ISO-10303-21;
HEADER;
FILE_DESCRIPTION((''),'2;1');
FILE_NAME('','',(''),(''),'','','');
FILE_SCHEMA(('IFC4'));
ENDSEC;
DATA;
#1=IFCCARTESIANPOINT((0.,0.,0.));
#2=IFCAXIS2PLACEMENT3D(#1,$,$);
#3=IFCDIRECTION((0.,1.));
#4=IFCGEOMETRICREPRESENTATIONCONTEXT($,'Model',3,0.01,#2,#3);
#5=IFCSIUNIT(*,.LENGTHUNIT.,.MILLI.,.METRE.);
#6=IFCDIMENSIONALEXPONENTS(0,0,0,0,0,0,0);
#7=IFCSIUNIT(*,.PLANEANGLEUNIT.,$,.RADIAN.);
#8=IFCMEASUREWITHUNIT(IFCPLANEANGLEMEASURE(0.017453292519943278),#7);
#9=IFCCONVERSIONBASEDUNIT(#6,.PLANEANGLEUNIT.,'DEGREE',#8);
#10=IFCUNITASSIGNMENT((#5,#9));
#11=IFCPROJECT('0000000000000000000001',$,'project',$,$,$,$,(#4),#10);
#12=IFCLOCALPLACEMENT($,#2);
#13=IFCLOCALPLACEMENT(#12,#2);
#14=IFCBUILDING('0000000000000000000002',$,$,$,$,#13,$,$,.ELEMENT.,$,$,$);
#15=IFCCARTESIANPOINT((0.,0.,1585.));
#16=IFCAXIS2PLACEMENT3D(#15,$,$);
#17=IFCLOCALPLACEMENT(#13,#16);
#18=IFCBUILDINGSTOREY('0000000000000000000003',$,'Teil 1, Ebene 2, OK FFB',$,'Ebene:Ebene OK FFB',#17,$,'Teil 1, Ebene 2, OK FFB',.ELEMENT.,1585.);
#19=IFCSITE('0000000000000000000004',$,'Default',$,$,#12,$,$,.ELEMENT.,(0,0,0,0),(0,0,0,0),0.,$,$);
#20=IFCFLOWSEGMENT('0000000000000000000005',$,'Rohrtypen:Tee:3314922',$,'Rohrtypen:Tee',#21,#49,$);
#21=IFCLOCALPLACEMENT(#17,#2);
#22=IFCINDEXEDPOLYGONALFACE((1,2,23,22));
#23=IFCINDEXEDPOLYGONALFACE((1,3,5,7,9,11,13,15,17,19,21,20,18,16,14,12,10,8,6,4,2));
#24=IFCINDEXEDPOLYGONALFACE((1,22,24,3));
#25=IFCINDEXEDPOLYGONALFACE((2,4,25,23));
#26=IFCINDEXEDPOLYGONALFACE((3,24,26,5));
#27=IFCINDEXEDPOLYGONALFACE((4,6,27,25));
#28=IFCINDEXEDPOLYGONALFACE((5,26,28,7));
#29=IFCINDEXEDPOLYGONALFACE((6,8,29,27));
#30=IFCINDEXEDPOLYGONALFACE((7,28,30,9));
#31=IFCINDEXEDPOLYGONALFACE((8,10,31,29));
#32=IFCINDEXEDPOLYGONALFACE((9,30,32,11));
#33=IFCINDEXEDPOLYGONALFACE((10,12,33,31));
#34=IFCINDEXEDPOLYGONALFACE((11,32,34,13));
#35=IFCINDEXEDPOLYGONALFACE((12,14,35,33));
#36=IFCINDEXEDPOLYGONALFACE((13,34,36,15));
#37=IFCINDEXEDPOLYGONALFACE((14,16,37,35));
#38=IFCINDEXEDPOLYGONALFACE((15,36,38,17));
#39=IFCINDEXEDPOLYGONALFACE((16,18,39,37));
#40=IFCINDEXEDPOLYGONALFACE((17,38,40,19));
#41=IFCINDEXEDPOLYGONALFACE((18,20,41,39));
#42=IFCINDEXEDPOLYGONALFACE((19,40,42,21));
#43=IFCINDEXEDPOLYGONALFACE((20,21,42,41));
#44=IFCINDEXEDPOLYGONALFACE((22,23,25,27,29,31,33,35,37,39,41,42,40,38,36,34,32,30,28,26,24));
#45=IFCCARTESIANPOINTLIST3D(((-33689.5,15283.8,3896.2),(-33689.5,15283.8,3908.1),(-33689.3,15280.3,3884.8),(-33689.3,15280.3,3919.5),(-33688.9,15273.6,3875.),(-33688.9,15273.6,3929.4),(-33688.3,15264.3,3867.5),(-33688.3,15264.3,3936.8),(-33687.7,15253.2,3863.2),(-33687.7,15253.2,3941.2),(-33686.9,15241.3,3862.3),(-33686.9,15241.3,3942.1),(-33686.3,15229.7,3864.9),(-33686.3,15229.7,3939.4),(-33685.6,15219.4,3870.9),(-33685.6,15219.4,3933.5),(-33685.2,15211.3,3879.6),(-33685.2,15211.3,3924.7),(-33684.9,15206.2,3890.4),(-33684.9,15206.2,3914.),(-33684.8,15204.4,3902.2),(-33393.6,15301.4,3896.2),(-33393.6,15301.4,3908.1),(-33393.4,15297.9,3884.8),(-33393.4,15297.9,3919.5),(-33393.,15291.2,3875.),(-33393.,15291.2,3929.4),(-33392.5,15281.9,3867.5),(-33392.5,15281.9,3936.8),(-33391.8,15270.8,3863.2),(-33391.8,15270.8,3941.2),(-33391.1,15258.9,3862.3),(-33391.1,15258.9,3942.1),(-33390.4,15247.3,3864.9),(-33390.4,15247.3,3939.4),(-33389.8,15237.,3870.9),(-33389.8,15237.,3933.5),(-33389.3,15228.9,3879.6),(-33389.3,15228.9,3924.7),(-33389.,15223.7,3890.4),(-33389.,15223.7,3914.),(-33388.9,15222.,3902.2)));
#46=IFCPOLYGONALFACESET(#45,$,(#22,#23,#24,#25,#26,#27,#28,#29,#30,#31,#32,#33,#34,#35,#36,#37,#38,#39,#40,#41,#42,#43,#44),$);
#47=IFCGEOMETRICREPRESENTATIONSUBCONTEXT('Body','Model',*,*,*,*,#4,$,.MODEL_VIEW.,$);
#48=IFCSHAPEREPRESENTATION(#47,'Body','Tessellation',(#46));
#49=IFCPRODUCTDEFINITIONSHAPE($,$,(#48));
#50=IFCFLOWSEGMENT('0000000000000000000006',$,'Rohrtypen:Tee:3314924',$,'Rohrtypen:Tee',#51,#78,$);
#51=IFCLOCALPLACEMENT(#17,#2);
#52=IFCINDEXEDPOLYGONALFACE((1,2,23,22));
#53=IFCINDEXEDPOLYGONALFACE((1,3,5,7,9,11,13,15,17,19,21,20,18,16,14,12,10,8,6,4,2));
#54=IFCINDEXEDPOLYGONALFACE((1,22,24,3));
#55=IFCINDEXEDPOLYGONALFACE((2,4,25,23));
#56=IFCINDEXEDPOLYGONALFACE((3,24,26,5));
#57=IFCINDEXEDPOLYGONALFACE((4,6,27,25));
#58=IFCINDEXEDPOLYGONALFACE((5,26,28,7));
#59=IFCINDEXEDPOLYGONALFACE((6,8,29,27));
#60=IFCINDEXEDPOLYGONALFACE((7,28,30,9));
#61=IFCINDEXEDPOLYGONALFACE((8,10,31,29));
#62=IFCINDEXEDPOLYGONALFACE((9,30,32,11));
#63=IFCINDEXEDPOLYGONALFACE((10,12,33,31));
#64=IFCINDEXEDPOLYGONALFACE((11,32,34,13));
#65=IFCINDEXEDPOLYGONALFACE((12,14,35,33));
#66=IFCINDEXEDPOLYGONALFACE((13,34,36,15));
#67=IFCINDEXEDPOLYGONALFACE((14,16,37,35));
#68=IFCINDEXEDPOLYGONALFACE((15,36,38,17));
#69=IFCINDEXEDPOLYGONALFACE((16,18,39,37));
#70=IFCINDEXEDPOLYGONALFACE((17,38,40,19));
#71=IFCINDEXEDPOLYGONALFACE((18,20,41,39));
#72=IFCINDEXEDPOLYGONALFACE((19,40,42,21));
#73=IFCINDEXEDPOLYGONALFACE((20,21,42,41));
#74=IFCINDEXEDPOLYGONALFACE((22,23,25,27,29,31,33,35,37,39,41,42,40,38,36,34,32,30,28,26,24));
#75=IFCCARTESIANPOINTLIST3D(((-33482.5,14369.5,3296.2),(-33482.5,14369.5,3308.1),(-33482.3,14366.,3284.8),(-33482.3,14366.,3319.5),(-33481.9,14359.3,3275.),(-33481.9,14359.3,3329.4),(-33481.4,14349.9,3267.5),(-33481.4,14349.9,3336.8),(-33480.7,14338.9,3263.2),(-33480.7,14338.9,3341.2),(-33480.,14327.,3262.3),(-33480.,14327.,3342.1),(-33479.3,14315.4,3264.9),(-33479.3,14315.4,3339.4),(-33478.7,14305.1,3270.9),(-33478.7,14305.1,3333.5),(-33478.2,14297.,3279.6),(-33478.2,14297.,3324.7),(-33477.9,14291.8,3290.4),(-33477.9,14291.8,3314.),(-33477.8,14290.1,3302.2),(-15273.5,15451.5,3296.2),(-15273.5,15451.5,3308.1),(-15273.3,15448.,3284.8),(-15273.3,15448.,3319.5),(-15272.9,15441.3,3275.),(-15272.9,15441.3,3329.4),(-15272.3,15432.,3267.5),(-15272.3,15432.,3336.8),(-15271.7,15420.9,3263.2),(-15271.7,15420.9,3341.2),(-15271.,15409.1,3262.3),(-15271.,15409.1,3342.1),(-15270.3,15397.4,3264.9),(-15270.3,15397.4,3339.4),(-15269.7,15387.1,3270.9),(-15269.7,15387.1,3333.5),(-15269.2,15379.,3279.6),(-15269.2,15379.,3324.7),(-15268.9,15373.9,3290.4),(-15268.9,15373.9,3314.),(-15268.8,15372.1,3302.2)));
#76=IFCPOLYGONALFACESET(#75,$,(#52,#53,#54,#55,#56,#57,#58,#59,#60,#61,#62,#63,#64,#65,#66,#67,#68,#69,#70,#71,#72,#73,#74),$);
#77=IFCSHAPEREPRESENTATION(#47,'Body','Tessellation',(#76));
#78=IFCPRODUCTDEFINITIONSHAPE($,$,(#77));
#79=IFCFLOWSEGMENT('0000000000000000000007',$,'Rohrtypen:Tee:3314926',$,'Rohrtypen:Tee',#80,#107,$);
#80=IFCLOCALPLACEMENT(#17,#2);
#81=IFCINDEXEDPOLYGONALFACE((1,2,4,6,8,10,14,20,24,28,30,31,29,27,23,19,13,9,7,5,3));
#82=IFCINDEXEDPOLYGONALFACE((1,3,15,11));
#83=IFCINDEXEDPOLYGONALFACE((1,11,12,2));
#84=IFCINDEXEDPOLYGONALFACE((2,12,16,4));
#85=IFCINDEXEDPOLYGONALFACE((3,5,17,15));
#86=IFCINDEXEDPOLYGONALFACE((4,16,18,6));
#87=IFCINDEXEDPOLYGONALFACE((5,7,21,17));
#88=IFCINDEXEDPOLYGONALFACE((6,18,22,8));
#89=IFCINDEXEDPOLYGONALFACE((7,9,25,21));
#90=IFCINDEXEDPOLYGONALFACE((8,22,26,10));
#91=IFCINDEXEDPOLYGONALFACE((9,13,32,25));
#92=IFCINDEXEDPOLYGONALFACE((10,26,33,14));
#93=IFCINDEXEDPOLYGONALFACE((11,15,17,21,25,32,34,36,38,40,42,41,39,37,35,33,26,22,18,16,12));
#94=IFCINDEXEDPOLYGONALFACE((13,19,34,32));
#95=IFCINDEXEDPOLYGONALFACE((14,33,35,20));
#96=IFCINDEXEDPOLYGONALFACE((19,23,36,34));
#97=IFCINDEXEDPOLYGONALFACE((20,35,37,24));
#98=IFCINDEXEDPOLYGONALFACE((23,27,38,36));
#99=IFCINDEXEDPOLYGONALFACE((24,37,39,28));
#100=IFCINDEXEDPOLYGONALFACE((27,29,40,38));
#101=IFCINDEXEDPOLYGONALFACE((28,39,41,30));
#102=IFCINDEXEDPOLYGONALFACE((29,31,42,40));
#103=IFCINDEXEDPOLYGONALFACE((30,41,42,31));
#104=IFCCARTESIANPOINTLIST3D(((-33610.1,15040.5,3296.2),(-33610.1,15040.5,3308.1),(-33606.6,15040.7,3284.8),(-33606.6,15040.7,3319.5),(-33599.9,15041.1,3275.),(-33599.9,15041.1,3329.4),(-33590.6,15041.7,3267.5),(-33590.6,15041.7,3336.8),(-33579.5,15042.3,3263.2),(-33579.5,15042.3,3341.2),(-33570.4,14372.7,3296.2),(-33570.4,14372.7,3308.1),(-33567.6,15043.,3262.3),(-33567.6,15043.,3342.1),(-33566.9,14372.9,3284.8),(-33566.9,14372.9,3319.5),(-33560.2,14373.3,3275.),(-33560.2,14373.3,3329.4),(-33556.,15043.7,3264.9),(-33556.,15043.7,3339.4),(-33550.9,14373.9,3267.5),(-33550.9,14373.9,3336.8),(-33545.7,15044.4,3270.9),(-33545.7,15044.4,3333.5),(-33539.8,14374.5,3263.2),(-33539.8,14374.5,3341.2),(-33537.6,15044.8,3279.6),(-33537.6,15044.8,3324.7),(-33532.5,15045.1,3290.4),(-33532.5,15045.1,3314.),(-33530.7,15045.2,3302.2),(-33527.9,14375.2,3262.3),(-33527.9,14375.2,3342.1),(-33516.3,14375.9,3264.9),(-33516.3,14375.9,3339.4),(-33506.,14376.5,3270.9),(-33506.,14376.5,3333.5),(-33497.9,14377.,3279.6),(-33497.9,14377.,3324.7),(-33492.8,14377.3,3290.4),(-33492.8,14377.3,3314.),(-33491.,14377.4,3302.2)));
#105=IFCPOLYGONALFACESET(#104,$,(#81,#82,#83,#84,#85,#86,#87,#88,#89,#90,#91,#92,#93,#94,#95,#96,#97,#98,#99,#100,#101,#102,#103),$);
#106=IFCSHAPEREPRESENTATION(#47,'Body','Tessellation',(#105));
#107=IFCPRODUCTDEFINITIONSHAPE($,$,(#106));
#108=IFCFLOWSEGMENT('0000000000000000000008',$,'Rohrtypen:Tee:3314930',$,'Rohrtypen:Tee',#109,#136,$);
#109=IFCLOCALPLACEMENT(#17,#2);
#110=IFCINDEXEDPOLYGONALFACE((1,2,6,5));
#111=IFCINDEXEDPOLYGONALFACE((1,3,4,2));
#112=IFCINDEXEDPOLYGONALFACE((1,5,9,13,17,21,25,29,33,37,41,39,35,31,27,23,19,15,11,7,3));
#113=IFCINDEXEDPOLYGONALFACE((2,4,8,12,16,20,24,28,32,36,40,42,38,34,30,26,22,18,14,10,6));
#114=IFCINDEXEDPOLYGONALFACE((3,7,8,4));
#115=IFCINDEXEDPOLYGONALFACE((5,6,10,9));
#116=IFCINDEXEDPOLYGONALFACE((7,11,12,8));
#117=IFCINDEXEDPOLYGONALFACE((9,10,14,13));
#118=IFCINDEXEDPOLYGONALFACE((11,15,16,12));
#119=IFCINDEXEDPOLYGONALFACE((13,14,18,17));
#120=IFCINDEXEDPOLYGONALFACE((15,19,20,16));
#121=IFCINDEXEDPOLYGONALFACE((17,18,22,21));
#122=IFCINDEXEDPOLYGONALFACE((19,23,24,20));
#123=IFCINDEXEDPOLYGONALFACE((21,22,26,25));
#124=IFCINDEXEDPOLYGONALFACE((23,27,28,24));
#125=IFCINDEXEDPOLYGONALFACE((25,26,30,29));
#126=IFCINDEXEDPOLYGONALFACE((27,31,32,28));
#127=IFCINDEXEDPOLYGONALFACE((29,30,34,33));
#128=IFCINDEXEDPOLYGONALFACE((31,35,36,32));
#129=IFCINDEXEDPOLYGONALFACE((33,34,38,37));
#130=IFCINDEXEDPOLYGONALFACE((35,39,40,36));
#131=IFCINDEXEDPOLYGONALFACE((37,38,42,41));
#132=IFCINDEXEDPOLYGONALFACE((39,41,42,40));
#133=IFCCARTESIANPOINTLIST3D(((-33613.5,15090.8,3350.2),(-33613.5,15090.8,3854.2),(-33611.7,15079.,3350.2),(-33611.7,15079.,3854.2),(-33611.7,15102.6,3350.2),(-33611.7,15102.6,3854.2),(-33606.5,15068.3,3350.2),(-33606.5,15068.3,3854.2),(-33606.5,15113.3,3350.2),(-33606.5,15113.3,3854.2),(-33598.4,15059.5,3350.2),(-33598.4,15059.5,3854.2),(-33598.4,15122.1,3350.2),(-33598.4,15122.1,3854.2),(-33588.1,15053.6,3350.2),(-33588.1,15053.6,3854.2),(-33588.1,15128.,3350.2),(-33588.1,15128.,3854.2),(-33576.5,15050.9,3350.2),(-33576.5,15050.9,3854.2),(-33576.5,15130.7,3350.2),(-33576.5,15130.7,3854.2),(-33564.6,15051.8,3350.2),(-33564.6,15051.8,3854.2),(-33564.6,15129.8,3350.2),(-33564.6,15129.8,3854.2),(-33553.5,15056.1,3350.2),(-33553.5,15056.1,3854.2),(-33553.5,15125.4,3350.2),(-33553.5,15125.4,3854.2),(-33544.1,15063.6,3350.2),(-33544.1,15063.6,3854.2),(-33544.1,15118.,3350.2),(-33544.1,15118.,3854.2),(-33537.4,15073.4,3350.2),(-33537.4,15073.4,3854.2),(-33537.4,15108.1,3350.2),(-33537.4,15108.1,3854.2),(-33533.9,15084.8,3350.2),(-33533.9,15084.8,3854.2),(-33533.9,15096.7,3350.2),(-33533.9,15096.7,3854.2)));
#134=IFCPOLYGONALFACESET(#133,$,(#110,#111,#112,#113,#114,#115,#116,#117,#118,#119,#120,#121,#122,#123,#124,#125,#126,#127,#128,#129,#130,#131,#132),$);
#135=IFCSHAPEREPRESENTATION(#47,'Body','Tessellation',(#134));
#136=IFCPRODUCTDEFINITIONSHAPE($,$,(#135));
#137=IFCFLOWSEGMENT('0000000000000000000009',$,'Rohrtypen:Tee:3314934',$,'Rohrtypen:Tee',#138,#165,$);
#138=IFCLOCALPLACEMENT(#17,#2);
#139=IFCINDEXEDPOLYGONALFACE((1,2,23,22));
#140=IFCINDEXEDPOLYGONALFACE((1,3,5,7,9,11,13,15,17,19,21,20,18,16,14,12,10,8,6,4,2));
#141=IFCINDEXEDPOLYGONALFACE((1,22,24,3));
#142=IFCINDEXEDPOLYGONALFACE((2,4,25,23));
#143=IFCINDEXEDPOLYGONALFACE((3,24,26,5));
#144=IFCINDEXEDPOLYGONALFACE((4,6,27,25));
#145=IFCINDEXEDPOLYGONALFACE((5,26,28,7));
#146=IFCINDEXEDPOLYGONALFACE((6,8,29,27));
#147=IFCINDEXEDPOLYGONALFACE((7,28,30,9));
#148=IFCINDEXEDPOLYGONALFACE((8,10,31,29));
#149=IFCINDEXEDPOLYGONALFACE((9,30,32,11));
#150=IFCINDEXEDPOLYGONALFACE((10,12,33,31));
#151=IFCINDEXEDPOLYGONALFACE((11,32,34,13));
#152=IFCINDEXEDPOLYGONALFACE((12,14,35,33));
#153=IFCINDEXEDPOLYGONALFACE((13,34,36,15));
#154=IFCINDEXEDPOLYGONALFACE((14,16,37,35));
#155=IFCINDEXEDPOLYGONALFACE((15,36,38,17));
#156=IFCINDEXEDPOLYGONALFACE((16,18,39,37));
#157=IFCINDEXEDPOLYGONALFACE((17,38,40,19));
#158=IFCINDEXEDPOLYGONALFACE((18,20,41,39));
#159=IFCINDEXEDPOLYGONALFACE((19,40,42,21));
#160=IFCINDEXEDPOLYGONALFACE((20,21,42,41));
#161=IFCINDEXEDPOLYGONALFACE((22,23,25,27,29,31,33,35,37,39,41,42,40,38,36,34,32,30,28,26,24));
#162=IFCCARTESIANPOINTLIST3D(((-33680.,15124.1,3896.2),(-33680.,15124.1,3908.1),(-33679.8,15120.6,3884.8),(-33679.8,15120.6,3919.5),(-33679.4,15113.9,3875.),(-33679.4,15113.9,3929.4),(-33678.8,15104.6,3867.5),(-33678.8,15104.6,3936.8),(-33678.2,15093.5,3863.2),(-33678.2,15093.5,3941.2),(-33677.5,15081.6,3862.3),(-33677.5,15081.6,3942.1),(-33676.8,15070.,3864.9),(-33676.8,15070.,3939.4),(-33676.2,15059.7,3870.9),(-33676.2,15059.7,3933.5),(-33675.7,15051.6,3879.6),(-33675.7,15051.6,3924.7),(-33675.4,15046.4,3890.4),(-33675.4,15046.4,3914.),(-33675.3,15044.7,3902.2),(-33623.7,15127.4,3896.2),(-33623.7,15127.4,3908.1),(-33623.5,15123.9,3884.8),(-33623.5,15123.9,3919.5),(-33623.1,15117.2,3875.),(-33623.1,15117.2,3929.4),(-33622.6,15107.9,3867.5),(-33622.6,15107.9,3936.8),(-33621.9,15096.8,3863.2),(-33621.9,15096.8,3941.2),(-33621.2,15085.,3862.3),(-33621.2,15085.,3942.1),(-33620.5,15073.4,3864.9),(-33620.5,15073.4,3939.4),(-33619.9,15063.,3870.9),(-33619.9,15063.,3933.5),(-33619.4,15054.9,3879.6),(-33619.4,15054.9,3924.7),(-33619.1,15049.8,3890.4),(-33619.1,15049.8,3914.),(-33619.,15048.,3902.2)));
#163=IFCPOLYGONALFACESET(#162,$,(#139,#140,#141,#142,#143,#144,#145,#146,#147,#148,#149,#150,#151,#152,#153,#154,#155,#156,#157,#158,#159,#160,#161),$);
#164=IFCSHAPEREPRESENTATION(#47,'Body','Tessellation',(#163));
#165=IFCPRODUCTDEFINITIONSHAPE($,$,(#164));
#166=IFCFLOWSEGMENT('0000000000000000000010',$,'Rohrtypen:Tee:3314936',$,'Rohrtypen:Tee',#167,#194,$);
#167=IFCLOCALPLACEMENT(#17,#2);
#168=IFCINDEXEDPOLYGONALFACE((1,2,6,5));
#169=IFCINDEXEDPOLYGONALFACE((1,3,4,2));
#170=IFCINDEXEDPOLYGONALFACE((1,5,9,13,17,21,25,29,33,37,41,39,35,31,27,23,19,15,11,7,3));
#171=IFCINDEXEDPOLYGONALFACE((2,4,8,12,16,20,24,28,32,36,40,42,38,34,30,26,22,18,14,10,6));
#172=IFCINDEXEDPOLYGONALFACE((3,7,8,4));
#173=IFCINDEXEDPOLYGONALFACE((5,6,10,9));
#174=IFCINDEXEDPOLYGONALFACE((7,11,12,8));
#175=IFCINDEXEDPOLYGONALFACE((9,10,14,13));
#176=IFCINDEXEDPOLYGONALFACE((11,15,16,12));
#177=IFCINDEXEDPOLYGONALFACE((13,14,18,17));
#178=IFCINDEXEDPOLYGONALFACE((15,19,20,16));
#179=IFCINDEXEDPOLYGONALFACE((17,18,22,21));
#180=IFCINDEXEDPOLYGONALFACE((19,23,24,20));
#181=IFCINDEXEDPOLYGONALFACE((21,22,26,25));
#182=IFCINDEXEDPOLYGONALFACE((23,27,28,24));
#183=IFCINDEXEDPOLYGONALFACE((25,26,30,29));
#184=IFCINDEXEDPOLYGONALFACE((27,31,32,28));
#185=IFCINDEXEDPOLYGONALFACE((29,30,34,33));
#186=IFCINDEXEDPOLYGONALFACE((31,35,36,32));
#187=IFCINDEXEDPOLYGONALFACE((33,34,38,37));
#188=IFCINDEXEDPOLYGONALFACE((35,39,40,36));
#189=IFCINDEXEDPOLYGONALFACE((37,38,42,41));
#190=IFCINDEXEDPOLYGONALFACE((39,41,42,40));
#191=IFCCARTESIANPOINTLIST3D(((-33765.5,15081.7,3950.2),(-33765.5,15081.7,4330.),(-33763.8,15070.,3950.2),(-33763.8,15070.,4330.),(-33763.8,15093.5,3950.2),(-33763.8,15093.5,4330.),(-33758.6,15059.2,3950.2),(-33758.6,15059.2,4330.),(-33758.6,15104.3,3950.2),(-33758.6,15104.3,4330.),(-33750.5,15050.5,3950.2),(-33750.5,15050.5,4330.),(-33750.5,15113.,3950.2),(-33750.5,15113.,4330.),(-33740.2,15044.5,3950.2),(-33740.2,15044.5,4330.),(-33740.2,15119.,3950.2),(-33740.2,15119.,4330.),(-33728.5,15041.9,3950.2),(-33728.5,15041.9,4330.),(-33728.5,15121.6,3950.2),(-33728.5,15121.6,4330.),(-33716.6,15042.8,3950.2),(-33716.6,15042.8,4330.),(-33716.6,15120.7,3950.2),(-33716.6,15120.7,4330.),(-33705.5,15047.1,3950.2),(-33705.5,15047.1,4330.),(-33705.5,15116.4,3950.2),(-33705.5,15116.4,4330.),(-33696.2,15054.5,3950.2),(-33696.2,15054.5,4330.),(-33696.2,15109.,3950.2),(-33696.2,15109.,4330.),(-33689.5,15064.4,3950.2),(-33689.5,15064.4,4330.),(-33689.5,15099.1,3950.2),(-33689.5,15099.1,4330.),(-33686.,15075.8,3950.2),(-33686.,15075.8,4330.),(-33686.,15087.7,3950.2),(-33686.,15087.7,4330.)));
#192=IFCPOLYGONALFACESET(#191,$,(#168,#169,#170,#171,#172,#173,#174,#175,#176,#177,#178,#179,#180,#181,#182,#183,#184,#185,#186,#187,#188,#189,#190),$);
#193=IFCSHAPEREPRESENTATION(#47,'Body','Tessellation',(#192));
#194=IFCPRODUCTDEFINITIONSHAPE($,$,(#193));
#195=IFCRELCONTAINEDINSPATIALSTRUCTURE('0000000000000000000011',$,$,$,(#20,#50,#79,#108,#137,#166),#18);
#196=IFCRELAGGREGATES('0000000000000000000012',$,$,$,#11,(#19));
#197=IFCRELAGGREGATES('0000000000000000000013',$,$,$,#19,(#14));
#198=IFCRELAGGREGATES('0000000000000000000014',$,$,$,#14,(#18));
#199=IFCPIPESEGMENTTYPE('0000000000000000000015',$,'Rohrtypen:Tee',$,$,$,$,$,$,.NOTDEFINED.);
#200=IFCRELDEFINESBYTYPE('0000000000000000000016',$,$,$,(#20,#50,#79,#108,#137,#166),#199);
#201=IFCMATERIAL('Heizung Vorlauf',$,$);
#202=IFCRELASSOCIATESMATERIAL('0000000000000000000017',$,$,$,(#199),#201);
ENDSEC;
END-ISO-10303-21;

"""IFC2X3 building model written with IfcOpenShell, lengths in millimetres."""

from ifc_helpers import new_model, entity, si_unit, converted_unit, direction, frame, frame_2d, origin, origin_2d_with_axis, place, context, subcontext, project, spatial, circle, extrude, material, type_object, element, save


model = new_model("IFC2X3")

# Units and contexts
model_context = context("Model", 3, precision=0.01, world=origin(), true_north=direction((0.0, 1.0)))
body_context = subcontext(model_context, "Body", "Model", "MODEL_VIEW")
ifc_project = project(units=[si_unit("LENGTHUNIT", "METRE", prefix="MILLI"), converted_unit("PLANEANGLEUNIT", "DEGREE", entity("IfcPlaneAngleMeasure", 0.017453292519943278), si_unit("PLANEANGLEUNIT", "RADIAN"), dimensions=[0, 0, 0, 0, 0, 0, 0])], contexts=[model_context])

# Site, building, storey
site_placement = place(None, origin())
site = spatial("IfcSite", under=ifc_project, at=site_placement, Name="Default", CompositionType="ELEMENT", RefLatitude=(0, 0, 0, 0), RefLongitude=(0, 0, 0, 0), RefElevation=0.0)
building_placement = place(site_placement, origin())
building = spatial("IfcBuilding", under=site, at=building_placement, CompositionType="ELEMENT")
storey_placement = place(building_placement, frame((0.0, 0.0, 1585.0)))
storey = spatial("IfcBuildingStorey", under=building, at=storey_placement, Name="Teil 1, Ebene 2, OK FFB", ObjectType="Ebene:Ebene OK FFB", LongName="Teil 1, Ebene 2, OK FFB", CompositionType="ELEMENT", Elevation=1585.0)

# Flow segments
ifc_material = material(Name="Heizung Vorlauf")
pipe_segment_type = type_object("IfcPipeSegmentType", Name="Rohrtypen:Tee", PredefinedType="NOTDEFINED", material=ifc_material)
flow_segment_1_placement = place(storey_placement, origin())
element("IfcFlowSegment", 1, at=flow_segment_1_placement, inside=storey, type_object=pipe_segment_type, Name="Rohrtypen:Tee:3314922", ObjectType="Rohrtypen:Tee", context=body_context, shape_type="SweptSolid", body=[
    extrude(circle(Radius=40.0, at=origin_2d_with_axis()), frame((-33687.1, 15244.3, 3902.2), z_axis=(0.998239, 0.059319, 0.0), x_axis=(0.059319, -0.998239, 0.0)), (0.0, 0.0, 1.0), 296.4),
])
flow_segment_2_placement = place(storey_placement, origin())
element("IfcFlowSegment", 2, at=flow_segment_2_placement, inside=storey, type_object=pipe_segment_type, Name="Rohrtypen:Tee:3314924", ObjectType="Rohrtypen:Tee", context=body_context, shape_type="SweptSolid", body=[
    extrude(circle(Radius=40.0, at=frame_2d((0.0, 0.0), x_axis=(1.0, 0.0))), frame((-33480.2, 14330.0, 3302.2), z_axis=(0.998239, 0.059319, 0.0), x_axis=(0.059319, -0.998239, 0.0)), (0.0, 0.0, 1.0), 18241.1),
])
flow_segment_3_placement = place(storey_placement, origin())
element("IfcFlowSegment", 3, at=flow_segment_3_placement, inside=storey, type_object=pipe_segment_type, Name="Rohrtypen:Tee:3314926", ObjectType="Rohrtypen:Tee", context=body_context, shape_type="SweptSolid", body=[
    extrude(circle(Radius=40.0, at=origin_2d_with_axis()), frame((-33570.6, 15042.9, 3302.2), z_axis=(0.059319, -0.998239, 0.0), x_axis=(0.998239, 0.059319, 0.0)), (0.0, 0.0, 1.0), 669.0),
])
flow_segment_4_placement = place(storey_placement, origin())
element("IfcFlowSegment", 4, at=flow_segment_4_placement, inside=storey, type_object=pipe_segment_type, Name="Rohrtypen:Tee:3314930", ObjectType="Rohrtypen:Tee", context=body_context, shape_type="SweptSolid", body=[
    extrude(circle(Radius=40.0, at=origin_2d_with_axis()), frame((-33573.5, 15090.8, 3350.2), z_axis=(0.0, 0.0, 1.0), x_axis=(-1.0, 0.0, 0.0)), (0.0, 0.0, 1.0), 504.0),
])
flow_segment_5_placement = place(storey_placement, origin())
element("IfcFlowSegment", 5, at=flow_segment_5_placement, inside=storey, type_object=pipe_segment_type, Name="Rohrtypen:Tee:3314934", ObjectType="Rohrtypen:Tee", context=body_context, shape_type="SweptSolid", body=[
    extrude(circle(Radius=40.0, at=frame_2d((0.0, 0.0), x_axis=(1.0, 0.0))), frame((-33677.6, 15084.6, 3902.2), z_axis=(0.998239, 0.059319, 0.0), x_axis=(0.059319, -0.998239, 0.0)), (0.0, 0.0, 1.0), 56.4),
])
flow_segment_6_placement = place(storey_placement, origin())
element("IfcFlowSegment", 6, at=flow_segment_6_placement, inside=storey, type_object=pipe_segment_type, Name="Rohrtypen:Tee:3314936", ObjectType="Rohrtypen:Tee", context=body_context, shape_type="SweptSolid", body=[
    extrude(circle(Radius=40.0, at=origin_2d_with_axis()), frame((-33725.5, 15081.7, 3950.2), z_axis=(0.0, 0.0, 1.0), x_axis=(-1.0, 0.0, 0.0)), (0.0, 0.0, 1.0), 379.8),
])

save(model, "model.ifc")
